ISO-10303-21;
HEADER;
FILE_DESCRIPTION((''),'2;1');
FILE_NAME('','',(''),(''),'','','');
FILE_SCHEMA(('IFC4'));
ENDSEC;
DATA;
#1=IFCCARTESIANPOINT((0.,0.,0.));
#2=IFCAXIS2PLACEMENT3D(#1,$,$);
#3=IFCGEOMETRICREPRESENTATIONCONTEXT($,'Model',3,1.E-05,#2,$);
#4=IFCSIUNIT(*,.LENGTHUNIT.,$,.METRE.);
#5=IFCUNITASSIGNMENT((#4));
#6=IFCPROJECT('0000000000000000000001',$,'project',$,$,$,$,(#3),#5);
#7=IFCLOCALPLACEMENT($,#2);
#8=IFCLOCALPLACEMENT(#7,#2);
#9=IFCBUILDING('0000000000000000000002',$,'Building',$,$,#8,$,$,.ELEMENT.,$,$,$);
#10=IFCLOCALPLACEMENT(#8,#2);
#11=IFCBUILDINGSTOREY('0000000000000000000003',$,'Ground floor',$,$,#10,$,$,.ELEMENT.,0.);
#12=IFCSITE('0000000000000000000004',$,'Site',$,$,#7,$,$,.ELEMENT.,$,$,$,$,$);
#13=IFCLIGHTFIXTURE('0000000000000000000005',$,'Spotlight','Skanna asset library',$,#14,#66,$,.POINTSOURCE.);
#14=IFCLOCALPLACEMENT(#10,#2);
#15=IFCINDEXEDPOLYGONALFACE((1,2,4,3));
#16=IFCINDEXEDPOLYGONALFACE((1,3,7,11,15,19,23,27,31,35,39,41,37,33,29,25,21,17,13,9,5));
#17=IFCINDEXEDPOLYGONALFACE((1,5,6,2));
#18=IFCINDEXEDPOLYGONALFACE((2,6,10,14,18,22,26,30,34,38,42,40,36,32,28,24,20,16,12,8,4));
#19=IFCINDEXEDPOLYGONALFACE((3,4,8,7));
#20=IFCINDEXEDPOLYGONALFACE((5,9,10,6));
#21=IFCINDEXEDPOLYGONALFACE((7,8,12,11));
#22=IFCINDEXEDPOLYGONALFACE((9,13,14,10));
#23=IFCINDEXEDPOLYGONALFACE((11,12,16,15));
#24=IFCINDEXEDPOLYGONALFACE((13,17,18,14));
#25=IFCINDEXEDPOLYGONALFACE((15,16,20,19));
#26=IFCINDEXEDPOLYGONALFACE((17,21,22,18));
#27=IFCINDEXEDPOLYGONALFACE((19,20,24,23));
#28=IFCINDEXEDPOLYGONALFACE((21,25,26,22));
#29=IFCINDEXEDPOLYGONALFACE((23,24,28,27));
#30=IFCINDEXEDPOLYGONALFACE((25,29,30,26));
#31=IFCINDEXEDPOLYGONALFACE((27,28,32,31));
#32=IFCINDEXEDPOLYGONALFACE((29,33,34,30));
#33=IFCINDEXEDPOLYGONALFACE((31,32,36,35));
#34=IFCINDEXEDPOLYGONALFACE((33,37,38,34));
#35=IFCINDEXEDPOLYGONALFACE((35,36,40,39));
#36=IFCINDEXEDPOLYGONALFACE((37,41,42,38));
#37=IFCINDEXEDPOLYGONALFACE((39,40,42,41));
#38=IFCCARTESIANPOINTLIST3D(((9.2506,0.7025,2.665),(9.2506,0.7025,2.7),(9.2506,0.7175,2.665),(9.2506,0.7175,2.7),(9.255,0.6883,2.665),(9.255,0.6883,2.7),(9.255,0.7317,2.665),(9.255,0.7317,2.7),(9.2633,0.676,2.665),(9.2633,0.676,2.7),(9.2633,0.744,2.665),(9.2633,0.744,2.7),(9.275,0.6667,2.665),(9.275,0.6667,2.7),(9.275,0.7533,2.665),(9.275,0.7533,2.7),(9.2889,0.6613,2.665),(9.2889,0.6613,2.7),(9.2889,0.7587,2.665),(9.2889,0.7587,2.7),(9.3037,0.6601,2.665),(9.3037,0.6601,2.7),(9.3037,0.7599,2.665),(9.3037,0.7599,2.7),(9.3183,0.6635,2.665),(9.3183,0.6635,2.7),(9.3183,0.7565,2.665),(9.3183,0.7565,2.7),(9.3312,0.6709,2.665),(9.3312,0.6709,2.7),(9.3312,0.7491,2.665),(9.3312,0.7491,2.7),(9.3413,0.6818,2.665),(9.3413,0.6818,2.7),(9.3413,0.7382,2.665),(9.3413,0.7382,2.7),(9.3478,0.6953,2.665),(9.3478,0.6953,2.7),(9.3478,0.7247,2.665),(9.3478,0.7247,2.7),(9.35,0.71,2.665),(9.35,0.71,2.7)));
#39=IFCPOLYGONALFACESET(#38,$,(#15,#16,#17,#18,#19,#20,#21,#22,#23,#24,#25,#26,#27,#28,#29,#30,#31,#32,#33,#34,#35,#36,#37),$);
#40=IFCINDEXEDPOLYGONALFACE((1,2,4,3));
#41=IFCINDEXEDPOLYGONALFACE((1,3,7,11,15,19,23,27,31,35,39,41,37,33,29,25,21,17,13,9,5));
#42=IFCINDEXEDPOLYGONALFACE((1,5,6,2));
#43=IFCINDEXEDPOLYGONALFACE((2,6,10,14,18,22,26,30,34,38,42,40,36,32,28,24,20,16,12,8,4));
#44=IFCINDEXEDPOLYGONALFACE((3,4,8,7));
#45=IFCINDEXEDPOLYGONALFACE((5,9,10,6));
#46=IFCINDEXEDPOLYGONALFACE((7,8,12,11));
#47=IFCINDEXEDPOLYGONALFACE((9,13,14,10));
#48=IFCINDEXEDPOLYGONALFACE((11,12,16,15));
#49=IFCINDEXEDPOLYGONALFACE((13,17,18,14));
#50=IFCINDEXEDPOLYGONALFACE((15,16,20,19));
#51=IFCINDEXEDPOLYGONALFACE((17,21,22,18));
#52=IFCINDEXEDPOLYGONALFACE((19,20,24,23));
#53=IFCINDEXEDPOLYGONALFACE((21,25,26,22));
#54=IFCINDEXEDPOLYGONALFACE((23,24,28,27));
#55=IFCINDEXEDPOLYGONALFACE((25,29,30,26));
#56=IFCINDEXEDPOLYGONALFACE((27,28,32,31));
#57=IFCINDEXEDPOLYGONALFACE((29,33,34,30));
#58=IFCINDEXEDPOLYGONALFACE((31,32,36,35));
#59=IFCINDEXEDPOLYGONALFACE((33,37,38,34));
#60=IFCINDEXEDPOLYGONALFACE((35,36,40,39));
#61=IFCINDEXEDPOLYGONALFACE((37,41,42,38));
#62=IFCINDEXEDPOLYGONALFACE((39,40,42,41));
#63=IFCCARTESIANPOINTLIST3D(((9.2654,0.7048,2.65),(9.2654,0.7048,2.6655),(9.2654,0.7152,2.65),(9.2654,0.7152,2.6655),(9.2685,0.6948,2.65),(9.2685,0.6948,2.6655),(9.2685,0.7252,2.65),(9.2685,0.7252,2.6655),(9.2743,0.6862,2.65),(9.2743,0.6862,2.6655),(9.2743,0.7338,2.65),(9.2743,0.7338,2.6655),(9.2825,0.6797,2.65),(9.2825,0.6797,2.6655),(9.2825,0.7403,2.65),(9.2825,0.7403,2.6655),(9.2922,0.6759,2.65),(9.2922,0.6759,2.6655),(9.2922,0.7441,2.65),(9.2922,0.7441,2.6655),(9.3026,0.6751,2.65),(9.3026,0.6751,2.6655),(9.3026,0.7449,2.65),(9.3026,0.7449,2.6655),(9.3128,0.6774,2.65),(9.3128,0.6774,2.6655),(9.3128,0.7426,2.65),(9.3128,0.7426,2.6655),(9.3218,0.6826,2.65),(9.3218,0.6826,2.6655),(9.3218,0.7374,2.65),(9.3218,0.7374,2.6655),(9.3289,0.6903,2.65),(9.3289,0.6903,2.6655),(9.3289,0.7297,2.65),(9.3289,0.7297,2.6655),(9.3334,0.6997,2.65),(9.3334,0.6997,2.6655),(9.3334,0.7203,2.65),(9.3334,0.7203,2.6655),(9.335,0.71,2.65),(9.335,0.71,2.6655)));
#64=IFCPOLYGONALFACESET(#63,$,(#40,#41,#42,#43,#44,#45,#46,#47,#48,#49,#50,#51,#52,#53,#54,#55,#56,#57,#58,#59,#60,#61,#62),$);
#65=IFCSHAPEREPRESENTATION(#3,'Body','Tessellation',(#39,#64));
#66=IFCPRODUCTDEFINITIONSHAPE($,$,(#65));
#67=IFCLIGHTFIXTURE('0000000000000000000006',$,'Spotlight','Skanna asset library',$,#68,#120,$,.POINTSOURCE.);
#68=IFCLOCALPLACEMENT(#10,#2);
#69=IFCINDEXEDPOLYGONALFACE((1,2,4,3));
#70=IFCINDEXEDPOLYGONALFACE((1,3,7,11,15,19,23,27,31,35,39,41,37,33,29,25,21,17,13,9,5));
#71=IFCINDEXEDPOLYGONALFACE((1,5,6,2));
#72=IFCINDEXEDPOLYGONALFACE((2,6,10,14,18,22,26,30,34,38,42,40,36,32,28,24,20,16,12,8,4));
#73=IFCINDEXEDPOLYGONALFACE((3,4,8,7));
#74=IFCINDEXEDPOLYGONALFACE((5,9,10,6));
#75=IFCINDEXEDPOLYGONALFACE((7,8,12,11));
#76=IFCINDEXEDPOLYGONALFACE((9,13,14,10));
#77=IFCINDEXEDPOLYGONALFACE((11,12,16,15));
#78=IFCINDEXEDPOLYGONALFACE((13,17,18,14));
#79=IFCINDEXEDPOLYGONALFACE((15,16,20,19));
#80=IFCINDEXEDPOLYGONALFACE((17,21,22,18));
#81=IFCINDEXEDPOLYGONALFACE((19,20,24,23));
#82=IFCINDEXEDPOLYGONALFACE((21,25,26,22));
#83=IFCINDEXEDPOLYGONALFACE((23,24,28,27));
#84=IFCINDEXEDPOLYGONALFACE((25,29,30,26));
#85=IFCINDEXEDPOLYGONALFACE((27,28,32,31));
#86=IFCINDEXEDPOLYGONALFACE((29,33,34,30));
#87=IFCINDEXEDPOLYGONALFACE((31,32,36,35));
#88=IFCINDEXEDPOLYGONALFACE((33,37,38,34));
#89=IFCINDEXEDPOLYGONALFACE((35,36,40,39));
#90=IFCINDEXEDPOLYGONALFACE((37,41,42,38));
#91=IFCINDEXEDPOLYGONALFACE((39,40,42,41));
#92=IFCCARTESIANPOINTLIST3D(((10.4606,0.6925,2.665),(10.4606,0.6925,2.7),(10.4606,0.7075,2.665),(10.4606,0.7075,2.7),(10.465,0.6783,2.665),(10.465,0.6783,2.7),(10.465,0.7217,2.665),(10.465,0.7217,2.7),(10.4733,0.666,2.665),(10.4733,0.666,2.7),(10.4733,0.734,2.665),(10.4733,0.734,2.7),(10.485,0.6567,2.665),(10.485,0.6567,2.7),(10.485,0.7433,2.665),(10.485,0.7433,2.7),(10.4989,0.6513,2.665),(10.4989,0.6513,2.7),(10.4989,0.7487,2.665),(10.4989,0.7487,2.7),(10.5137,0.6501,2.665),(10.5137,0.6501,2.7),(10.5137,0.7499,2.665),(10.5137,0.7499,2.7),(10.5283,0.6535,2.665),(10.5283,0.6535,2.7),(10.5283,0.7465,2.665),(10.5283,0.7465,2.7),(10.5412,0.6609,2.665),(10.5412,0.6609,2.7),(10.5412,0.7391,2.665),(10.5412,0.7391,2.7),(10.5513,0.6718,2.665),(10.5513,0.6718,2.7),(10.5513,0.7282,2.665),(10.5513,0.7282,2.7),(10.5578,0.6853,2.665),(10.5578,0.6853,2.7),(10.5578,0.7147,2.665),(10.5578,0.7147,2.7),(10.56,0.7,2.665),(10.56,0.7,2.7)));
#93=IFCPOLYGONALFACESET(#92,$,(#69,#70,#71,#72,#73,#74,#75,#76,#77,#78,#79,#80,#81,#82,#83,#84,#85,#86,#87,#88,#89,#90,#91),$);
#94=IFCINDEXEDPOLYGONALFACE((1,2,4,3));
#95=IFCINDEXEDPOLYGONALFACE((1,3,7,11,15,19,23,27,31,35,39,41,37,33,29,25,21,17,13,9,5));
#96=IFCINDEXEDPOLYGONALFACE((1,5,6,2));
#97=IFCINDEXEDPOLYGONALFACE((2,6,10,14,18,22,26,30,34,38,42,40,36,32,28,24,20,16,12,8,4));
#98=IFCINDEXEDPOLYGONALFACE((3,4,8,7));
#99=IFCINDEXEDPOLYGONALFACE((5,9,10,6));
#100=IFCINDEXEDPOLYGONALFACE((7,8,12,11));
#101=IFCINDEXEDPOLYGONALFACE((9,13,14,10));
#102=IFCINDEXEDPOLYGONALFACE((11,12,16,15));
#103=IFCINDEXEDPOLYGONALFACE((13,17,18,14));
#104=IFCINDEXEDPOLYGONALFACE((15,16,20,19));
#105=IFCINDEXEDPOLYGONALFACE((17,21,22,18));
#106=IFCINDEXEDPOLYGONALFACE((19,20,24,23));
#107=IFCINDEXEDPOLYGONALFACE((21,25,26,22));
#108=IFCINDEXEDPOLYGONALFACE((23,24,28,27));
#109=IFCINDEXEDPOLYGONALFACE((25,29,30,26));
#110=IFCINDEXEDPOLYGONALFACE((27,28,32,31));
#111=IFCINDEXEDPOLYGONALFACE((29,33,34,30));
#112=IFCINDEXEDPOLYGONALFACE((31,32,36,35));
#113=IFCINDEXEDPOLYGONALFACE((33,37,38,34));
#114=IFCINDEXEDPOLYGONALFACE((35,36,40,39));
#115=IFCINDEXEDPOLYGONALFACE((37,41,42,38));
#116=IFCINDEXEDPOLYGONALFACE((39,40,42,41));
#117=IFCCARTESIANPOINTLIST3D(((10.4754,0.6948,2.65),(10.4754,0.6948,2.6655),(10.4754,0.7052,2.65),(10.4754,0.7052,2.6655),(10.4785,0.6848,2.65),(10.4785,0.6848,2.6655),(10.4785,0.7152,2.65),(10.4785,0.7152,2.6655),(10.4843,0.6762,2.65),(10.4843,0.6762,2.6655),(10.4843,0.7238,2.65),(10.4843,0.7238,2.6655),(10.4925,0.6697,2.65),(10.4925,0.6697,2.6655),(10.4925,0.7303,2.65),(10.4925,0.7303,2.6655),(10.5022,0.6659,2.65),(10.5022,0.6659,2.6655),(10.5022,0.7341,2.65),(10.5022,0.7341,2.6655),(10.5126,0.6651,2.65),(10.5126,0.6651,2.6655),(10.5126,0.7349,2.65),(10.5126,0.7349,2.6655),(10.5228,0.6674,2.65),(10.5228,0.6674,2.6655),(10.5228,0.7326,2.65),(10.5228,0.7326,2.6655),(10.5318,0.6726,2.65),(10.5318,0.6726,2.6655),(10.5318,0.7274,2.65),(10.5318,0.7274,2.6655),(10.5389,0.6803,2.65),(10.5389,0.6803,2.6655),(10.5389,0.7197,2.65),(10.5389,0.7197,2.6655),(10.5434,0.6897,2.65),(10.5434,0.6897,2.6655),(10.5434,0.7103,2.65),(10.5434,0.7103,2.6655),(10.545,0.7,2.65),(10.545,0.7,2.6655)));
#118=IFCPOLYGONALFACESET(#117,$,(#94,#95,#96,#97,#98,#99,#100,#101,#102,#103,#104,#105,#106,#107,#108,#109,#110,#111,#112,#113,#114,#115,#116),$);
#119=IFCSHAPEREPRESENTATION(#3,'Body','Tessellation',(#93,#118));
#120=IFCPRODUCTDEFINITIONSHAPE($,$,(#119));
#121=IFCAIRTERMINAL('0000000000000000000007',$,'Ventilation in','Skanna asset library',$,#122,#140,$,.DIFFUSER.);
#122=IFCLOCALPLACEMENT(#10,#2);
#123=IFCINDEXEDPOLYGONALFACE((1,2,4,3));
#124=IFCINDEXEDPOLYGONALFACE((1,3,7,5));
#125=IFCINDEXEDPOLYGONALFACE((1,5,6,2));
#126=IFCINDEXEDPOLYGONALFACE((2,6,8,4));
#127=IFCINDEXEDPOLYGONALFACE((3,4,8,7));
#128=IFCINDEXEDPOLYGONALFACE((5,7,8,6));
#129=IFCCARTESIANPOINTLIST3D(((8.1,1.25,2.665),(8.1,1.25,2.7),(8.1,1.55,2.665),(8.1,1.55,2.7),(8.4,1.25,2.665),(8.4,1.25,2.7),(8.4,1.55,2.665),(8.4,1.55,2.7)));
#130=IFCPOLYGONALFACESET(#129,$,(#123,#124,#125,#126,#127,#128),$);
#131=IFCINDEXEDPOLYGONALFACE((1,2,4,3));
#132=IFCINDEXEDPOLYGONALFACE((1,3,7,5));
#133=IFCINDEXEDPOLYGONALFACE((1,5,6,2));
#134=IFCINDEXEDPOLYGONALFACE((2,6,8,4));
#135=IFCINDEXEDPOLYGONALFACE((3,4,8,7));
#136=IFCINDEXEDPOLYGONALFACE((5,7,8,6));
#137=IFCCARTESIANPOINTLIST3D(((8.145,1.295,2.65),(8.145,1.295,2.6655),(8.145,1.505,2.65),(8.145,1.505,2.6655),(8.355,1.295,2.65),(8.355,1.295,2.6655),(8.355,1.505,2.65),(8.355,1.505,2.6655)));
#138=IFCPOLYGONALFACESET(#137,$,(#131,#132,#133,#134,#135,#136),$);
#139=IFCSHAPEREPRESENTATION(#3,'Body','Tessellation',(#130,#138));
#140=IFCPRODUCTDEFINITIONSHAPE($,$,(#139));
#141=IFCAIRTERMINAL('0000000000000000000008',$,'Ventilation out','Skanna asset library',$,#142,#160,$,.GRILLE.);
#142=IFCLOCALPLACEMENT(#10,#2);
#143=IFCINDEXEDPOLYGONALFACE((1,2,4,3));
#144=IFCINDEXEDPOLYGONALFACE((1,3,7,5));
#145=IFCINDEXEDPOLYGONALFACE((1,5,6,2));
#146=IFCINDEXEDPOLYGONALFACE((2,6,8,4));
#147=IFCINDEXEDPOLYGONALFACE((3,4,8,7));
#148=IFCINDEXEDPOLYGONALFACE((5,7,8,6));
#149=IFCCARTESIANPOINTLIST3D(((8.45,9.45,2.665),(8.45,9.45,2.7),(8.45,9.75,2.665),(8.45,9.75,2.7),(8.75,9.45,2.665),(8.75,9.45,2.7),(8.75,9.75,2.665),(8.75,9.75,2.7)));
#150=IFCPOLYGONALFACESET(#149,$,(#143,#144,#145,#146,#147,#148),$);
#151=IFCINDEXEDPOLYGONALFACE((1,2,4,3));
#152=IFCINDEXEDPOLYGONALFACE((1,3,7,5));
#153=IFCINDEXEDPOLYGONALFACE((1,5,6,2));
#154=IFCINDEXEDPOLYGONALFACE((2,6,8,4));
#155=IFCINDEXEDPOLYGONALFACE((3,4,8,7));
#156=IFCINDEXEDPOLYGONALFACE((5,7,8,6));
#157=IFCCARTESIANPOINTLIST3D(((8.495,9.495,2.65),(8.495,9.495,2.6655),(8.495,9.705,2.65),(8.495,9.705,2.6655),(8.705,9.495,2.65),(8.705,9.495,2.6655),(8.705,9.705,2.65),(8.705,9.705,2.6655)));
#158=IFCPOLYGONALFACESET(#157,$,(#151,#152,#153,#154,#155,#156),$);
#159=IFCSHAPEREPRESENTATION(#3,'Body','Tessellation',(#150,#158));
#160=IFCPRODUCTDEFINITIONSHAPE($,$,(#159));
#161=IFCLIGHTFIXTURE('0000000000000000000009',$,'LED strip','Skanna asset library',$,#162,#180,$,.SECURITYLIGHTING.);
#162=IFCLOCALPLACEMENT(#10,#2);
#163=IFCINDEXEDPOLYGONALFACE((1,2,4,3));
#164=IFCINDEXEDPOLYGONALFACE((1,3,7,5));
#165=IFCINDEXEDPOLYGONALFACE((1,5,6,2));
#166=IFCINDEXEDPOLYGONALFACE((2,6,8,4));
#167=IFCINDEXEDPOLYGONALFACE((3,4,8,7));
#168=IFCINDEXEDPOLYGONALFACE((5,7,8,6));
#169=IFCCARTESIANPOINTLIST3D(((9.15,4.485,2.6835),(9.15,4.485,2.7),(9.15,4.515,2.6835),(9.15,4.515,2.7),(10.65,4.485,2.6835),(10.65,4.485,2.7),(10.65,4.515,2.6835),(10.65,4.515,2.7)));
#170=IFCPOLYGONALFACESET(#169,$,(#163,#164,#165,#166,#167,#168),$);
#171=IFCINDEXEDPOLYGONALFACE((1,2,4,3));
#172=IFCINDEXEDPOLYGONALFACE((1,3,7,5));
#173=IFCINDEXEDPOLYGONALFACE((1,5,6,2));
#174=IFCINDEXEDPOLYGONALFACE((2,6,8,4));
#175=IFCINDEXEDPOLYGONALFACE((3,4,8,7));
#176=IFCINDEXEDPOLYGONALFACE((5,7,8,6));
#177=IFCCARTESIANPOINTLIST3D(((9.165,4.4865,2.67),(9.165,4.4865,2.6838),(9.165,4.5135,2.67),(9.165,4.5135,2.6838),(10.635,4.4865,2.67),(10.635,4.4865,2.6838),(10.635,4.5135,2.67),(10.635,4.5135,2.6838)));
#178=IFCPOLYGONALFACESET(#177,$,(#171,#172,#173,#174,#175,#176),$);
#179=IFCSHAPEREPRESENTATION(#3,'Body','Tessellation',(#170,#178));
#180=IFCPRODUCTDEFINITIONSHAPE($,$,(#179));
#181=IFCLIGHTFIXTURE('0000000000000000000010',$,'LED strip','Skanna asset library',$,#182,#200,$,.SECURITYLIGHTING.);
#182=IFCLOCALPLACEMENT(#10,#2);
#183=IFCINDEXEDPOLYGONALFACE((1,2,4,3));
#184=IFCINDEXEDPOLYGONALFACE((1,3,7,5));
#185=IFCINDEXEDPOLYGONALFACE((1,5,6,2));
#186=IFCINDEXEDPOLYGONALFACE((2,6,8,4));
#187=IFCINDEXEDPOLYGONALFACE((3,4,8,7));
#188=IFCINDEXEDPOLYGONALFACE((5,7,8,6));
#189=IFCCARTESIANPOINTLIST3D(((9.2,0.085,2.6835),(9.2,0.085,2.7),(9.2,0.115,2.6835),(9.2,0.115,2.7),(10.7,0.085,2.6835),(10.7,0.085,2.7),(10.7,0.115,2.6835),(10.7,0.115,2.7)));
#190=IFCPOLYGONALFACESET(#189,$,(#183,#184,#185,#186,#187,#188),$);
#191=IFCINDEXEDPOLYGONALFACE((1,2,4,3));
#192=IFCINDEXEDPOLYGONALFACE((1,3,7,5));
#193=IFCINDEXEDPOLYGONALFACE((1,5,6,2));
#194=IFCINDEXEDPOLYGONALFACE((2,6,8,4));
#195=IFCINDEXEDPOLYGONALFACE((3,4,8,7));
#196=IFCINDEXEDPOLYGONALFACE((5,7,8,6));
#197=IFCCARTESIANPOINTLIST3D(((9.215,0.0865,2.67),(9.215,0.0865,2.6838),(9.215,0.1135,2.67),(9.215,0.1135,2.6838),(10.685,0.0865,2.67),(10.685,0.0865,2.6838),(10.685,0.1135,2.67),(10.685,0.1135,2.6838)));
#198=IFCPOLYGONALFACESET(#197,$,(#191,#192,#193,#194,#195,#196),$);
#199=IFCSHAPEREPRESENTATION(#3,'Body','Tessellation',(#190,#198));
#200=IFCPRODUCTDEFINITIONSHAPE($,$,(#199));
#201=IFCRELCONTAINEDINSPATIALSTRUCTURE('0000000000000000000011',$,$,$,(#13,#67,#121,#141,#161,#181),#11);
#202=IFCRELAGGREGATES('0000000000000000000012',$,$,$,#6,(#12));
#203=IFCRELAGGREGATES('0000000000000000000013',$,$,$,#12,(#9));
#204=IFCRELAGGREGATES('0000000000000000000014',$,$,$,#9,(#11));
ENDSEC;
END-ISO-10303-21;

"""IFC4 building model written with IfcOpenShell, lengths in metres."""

from ifc_helpers import new_model, si_unit, frame, origin, origin_2d, place, context, project, spatial, rectangle, circle, extrude, element, save


model = new_model("IFC4")

# Units and contexts
model_context = context("Model", 3, precision=1e-05, world=origin())
ifc_project = project(units=[si_unit("LENGTHUNIT", "METRE")], contexts=[model_context])

# Site, building, storey
site_placement = place(None, origin())
site = spatial("IfcSite", under=ifc_project, at=site_placement, Name="Site", CompositionType="ELEMENT")
building_placement = place(site_placement, origin())
building = spatial("IfcBuilding", under=site, at=building_placement, Name="Building", CompositionType="ELEMENT")
storey_placement = place(building_placement, origin())
storey = spatial("IfcBuildingStorey", under=building, at=storey_placement, Name="Ground floor", CompositionType="ELEMENT", Elevation=0.0)

# Light fixtures
for number, where, z_axis, x_axis, name in (
    (1, (9.3, 0.71, 2.65), (0.0, 0.0, 1.0), (1.0, 0.0, 0.0), "Spotlight"),
    (2, (10.51, 0.7, 2.65), (0.0, 0.0, 1.0), (1.0, 0.0, 0.0), "Spotlight"),
):
    element("IfcLightFixture", number, at=place(storey_placement, frame(where, z_axis=z_axis, x_axis=x_axis)), inside=storey, Name=name, Description="Skanna asset library", PredefinedType="POINTSOURCE", context=model_context, shape_type="SweptSolid", body=[
        extrude(circle(Radius=0.05, at=origin_2d()), frame((0.0, 0.0, 0.015)), (0.0, 0.0, 1.0), 0.035),
        extrude(circle(Radius=0.035, at=origin_2d()), origin(), (0.0, 0.0, 1.0), 0.0155),
    ])

# Air terminals
air_terminal_1_placement = place(storey_placement, frame((8.25, 1.4, 2.65), z_axis=(0.0, 0.0, 1.0), x_axis=(1.0, 0.0, 0.0)))
element("IfcAirTerminal", 3, at=air_terminal_1_placement, inside=storey, Name="Ventilation in", Description="Skanna asset library", PredefinedType="DIFFUSER", context=model_context, shape_type="SweptSolid", body=[
    extrude(rectangle(XDim=0.3, YDim=0.3, at=origin_2d()), frame((0.0, 0.0, 0.015)), (0.0, 0.0, 1.0), 0.035),
    extrude(rectangle(XDim=0.21, YDim=0.21, at=origin_2d()), origin(), (0.0, 0.0, 1.0), 0.0155),
])
air_terminal_2_placement = place(storey_placement, frame((8.6, 9.6, 2.65), z_axis=(0.0, 0.0, 1.0), x_axis=(1.0, 0.0, 0.0)))
element("IfcAirTerminal", 4, at=air_terminal_2_placement, inside=storey, Name="Ventilation out", Description="Skanna asset library", PredefinedType="GRILLE", context=model_context, shape_type="SweptSolid", body=[
    extrude(rectangle(XDim=0.3, YDim=0.3, at=origin_2d()), frame((0.0, 0.0, 0.015)), (0.0, 0.0, 1.0), 0.035),
    extrude(rectangle(XDim=0.21, YDim=0.21, at=origin_2d()), origin(), (0.0, 0.0, 1.0), 0.0155),
])

# Light fixtures
for number, where, z_axis, x_axis, name in (
    (5, (9.9, 4.5, 2.67), (0.0, 0.0, 1.0), (1.0, 0.0, 0.0), "LED strip"),
    (6, (9.95, 0.1, 2.67), (0.0, 0.0, 1.0), (1.0, 0.0, 0.0), "LED strip"),
):
    element("IfcLightFixture", number, at=place(storey_placement, frame(where, z_axis=z_axis, x_axis=x_axis)), inside=storey, Name=name, Description="Skanna asset library", PredefinedType="SECURITYLIGHTING", context=model_context, shape_type="SweptSolid", body=[
        extrude(rectangle(XDim=1.5, YDim=0.03, at=origin_2d()), frame((0.0, 0.0, 0.0135)), (0.0, 0.0, 1.0), 0.0165),
        extrude(rectangle(XDim=1.47, YDim=0.027, at=origin_2d()), origin(), (0.0, 0.0, 1.0), 0.0138),
    ])

save(model, "model.ifc")
